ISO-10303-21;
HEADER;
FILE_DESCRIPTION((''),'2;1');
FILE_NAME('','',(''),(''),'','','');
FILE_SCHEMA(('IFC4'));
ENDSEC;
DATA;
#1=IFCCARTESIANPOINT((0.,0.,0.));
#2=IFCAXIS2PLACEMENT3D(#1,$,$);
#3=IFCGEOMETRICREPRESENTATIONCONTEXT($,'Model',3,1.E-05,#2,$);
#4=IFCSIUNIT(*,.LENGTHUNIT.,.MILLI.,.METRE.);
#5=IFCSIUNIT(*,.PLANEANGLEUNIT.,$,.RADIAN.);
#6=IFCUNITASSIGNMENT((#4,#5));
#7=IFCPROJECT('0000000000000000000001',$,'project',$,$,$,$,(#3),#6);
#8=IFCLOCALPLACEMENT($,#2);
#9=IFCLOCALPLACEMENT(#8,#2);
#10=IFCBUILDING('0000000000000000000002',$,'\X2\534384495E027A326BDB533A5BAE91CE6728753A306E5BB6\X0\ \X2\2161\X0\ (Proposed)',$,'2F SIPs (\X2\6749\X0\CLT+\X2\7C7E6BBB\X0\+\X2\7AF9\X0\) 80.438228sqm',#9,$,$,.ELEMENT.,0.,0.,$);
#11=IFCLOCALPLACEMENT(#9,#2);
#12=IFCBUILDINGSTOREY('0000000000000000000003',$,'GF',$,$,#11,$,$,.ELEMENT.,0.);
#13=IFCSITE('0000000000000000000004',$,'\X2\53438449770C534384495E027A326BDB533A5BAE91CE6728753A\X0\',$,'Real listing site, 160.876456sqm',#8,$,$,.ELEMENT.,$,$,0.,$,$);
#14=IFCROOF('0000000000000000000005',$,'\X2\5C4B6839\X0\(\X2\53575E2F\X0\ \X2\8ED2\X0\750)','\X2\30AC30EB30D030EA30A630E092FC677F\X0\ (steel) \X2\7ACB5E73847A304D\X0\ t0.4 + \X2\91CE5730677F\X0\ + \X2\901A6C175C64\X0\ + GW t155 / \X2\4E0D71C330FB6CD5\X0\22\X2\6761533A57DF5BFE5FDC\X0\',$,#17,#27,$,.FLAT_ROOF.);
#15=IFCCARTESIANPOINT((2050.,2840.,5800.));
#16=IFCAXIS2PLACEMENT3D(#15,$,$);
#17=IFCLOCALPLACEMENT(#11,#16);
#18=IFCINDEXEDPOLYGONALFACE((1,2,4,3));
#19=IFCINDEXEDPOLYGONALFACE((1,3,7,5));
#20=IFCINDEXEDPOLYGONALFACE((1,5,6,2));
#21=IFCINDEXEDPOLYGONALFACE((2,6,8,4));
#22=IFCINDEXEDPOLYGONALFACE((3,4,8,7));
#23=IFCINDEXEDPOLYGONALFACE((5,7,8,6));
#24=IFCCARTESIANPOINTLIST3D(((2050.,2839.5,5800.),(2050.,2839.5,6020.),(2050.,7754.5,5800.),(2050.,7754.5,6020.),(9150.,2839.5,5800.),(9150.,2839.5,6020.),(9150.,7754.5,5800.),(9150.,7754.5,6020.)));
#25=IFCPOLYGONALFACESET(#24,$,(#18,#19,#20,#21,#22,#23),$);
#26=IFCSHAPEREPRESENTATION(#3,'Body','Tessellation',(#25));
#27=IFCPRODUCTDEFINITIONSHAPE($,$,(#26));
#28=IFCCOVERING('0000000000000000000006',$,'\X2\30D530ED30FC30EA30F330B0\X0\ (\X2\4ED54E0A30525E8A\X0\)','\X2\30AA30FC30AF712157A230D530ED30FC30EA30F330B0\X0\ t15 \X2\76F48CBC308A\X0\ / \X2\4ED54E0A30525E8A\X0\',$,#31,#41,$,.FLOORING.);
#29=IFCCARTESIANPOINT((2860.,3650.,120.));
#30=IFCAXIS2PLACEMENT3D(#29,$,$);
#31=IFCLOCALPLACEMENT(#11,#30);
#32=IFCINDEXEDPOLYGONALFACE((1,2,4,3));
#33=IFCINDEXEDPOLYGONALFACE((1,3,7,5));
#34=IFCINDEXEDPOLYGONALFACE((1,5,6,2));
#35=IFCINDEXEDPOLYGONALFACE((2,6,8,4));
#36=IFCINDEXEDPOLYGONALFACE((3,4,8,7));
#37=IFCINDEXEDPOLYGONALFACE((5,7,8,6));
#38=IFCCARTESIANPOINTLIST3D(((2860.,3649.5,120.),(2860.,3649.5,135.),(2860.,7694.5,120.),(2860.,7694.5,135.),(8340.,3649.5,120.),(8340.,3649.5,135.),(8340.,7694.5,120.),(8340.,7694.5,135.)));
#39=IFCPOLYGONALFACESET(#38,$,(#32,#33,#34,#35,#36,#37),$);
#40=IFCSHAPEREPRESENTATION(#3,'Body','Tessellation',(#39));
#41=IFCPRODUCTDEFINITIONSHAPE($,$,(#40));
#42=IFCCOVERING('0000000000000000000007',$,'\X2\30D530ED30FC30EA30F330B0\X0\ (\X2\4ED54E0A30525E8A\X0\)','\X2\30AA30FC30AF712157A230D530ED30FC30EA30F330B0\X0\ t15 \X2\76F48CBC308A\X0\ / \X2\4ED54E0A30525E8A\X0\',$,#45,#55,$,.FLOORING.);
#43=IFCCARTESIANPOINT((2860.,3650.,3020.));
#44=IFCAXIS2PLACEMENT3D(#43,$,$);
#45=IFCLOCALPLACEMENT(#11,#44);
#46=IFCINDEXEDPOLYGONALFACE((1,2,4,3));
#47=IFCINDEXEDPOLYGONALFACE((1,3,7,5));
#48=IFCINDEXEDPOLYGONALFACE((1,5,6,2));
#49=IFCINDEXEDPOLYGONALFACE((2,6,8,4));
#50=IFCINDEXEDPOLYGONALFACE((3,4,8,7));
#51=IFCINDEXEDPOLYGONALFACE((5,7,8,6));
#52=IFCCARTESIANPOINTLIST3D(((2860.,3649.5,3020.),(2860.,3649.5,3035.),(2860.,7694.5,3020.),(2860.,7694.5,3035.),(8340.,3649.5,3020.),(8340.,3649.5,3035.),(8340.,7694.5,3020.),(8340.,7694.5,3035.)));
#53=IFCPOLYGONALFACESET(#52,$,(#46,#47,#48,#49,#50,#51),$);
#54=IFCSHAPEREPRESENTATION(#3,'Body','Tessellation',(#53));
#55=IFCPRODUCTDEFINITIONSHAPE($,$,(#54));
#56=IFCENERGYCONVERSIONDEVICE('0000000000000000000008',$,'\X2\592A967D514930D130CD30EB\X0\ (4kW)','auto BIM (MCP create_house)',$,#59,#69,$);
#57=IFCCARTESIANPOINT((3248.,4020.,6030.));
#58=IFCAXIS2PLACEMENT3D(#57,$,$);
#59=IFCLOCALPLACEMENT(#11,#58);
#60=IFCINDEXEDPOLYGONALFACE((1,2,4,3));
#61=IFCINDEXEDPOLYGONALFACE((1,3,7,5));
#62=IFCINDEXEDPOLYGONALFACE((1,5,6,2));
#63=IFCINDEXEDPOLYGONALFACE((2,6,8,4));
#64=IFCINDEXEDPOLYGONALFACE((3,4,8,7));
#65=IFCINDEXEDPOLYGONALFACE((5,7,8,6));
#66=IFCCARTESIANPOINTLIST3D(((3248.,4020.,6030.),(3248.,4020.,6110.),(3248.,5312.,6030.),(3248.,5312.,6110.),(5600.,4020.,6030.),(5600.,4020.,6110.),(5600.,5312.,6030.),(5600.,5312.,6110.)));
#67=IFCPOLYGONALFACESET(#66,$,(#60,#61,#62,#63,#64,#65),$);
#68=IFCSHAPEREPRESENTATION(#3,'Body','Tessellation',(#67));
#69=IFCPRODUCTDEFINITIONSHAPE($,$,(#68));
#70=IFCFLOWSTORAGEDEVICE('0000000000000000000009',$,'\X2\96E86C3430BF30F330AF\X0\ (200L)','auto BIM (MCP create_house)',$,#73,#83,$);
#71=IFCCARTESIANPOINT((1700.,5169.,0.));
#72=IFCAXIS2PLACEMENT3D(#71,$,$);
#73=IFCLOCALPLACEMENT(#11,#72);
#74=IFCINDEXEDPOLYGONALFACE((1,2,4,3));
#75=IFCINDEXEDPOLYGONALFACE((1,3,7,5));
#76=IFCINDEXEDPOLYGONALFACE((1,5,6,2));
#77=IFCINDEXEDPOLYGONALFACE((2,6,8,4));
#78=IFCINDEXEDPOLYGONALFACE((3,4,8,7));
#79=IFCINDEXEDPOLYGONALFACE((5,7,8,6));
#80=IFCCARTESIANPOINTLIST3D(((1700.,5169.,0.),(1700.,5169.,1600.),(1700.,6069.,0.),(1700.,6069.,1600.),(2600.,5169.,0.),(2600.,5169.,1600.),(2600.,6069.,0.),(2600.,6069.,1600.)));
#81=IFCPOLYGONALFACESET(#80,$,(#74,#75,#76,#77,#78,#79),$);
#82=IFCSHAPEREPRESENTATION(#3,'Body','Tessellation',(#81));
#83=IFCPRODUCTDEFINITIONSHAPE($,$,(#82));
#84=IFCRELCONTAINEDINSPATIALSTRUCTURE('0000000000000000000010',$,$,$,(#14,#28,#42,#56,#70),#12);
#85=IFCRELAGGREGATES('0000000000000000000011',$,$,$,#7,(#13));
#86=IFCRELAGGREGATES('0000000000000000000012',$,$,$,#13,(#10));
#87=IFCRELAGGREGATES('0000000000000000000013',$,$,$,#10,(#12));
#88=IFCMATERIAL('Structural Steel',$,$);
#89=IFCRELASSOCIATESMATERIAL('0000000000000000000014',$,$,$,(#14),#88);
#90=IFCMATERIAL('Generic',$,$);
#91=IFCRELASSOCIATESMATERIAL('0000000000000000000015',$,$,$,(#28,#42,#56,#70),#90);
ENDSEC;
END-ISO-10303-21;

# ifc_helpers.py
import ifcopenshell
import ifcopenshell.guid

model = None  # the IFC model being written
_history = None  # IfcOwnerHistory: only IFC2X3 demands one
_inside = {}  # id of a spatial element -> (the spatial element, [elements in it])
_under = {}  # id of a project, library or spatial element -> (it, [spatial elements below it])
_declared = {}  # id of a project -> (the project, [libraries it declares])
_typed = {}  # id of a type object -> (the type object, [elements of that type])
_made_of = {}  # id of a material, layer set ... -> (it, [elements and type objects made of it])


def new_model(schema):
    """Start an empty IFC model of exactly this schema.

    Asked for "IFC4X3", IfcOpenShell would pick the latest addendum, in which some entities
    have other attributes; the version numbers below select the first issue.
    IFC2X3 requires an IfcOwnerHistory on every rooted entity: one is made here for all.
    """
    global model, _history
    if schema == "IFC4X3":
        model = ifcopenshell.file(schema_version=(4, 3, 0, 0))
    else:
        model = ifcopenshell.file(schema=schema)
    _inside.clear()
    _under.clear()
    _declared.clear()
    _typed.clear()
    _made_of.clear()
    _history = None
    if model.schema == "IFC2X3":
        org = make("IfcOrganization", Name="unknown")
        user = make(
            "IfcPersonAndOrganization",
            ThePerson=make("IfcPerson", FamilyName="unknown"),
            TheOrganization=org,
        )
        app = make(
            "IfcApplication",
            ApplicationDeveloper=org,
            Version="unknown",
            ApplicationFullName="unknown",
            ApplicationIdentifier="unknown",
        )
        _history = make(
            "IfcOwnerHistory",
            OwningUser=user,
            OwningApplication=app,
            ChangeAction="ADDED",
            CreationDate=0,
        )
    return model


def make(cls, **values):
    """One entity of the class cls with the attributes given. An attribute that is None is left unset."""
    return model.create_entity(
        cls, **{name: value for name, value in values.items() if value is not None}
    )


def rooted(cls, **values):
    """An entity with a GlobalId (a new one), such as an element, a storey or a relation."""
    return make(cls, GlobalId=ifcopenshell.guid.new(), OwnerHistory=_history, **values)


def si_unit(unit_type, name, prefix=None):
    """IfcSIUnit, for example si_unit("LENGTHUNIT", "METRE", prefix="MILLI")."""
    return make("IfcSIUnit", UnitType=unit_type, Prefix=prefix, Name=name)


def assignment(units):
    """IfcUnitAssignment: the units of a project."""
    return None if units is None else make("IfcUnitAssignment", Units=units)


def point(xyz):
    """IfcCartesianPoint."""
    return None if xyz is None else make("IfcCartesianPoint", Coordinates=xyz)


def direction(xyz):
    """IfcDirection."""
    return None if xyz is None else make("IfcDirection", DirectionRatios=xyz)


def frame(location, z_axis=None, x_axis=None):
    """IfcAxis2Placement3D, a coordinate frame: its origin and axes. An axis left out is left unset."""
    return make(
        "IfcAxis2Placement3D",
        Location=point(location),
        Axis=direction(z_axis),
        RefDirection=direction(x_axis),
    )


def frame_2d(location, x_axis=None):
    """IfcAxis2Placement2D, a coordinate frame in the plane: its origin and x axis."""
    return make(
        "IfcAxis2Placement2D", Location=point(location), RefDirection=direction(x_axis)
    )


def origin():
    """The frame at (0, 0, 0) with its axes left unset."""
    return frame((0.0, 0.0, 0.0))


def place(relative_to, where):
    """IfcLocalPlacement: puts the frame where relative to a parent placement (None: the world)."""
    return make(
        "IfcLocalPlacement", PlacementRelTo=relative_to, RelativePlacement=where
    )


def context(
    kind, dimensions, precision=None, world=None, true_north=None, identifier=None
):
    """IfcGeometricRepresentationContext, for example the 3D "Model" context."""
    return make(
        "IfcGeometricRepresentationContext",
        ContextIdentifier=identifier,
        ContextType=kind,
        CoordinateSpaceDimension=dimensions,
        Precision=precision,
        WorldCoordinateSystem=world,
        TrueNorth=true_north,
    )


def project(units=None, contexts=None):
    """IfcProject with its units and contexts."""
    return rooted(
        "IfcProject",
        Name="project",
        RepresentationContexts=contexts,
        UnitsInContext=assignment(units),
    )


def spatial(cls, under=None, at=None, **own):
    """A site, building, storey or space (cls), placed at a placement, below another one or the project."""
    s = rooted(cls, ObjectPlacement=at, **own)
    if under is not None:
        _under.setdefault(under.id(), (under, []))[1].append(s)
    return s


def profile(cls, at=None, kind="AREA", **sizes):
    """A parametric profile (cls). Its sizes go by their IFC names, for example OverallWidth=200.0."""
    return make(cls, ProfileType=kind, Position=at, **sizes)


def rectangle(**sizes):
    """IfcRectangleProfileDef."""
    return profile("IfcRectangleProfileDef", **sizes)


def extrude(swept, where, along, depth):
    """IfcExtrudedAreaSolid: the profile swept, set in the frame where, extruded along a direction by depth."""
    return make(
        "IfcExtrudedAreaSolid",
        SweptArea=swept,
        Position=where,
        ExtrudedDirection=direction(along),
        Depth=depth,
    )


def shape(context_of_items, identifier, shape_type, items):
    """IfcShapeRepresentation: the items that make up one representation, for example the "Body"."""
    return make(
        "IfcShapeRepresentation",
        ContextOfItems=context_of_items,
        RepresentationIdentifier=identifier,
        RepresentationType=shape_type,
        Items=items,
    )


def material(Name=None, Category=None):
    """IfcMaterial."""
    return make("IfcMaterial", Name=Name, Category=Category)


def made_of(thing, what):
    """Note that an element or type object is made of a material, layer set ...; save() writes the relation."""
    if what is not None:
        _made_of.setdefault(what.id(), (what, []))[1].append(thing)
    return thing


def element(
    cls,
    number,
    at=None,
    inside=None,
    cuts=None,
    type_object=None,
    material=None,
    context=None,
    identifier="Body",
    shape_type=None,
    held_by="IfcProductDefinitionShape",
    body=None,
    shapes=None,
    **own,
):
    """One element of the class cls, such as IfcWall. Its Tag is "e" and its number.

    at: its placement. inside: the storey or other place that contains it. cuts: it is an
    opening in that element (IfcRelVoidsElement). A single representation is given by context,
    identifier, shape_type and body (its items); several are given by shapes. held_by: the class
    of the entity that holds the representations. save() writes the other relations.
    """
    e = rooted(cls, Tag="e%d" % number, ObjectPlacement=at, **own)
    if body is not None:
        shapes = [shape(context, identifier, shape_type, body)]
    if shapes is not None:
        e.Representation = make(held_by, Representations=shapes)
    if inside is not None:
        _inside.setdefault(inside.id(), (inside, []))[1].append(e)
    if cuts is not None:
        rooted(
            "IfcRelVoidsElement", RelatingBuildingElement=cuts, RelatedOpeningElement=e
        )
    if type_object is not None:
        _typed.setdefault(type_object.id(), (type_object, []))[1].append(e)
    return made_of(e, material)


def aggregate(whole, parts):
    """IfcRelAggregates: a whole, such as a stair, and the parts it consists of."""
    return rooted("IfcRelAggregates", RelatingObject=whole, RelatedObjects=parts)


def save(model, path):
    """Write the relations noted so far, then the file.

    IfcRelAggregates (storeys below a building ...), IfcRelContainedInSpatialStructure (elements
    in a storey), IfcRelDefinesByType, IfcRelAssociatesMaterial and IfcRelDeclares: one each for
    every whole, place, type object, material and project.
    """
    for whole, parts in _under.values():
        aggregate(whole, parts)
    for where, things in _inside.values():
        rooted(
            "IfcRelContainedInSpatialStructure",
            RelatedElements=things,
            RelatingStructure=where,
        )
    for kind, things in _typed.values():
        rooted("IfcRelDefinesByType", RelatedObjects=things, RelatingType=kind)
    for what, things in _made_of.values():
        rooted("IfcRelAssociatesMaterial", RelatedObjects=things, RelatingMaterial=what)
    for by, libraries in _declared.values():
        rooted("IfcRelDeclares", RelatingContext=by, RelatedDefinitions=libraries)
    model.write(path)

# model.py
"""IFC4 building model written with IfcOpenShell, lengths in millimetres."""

from ifc_helpers import new_model, si_unit, frame, frame_2d, origin, place, context, project, spatial, rectangle, extrude, material, element, save


model = new_model("IFC4")

# Units and contexts
model_context = context("Model", 3, precision=1e-05, world=origin())
ifc_project = project(units=[si_unit("LENGTHUNIT", "METRE", prefix="MILLI"), si_unit("PLANEANGLEUNIT", "RADIAN")], contexts=[model_context])

# Site, building, storey
site_placement = place(None, origin())
site = spatial("IfcSite", under=ifc_project, at=site_placement, Name="千葉県千葉市稲毛区宮野木町", ObjectType="Real listing site, 160.876456sqm", CompositionType="ELEMENT", RefElevation=0.0)
building_placement = place(site_placement, origin())
building = spatial("IfcBuilding", under=site, at=building_placement, Name="千葉市稲毛区宮野木町の家 Ⅱ (Proposed)", ObjectType="2F SIPs (杉CLT+籾殻+竹) 80.438228sqm", CompositionType="ELEMENT", ElevationOfRefHeight=0.0, ElevationOfTerrain=0.0)
storey_placement = place(building_placement, origin())
storey = spatial("IfcBuildingStorey", under=building, at=storey_placement, Name="GF", CompositionType="ELEMENT", Elevation=0.0)

# Roof
ifc_material_1 = material(Name="Structural Steel")
for number, where, name in (
    (1, (2050.0, 2840.0, 5800.0), "屋根(南帯 軒750)"),
):
    element("IfcRoof", number, at=place(storey_placement, frame(where)), inside=storey, material=ifc_material_1, Name=name, Description="ガルバリウム鋼板 (steel) 立平葺き t0.4 + 野地板 + 通気層 + GW t155 / 不燃・法22条区域対応", PredefinedType="FLAT_ROOF", context=model_context, shape_type="SweptSolid", body=[
        extrude(rectangle(XDim=7100.0, YDim=4915.0, at=frame_2d((3550.0, 2457.0))), frame((2050.0, 2840.0, 5800.0)), (0.0, 0.0, 1.0), 220.0),
    ])

# Coverings
ifc_material_2 = material(Name="Generic")
covering_1_placement = place(storey_placement, frame((2860.0, 3650.0, 120.0)))
element("IfcCovering", 2, at=covering_1_placement, inside=storey, material=ifc_material_2, Name="フローリング (仕上げ床)", Description="オーク無垢フローリング t15 直貼り / 仕上げ床", PredefinedType="FLOORING", context=model_context, shape_type="SweptSolid", body=[
    extrude(rectangle(XDim=5480.0, YDim=4045.0, at=frame_2d((2740.0, 2022.0))), frame((2860.0, 3650.0, 120.0)), (0.0, 0.0, 1.0), 15.0),
])
covering_2_placement = place(storey_placement, frame((2860.0, 3650.0, 3020.0)))
element("IfcCovering", 3, at=covering_2_placement, inside=storey, material=ifc_material_2, Name="フローリング (仕上げ床)", Description="オーク無垢フローリング t15 直貼り / 仕上げ床", PredefinedType="FLOORING", context=model_context, shape_type="SweptSolid", body=[
    extrude(rectangle(XDim=5480.0, YDim=4045.0, at=frame_2d((2740.0, 2022.0))), frame((2860.0, 3650.0, 3020.0)), (0.0, 0.0, 1.0), 15.0),
])

# Energy conversion device
energy_conversion_device_placement = place(storey_placement, frame((3248.0, 4020.0, 6030.0)))
element("IfcEnergyConversionDevice", 4, at=energy_conversion_device_placement, inside=storey, material=ifc_material_2, Name="太陽光パネル (4kW)", Description="auto BIM (MCP create_house)", context=model_context, shape_type="SweptSolid", body=[
    extrude(rectangle(XDim=2352.0, YDim=1292.0, at=frame_2d((1176.0, 646.0))), frame((3248.0, 4020.0, 6030.0)), (0.0, 0.0, 1.0), 80.0),
])

# Flow storage device
flow_storage_device_placement = place(storey_placement, frame((1700.0, 5169.0, 0.0)))
element("IfcFlowStorageDevice", 5, at=flow_storage_device_placement, inside=storey, material=ifc_material_2, Name="雨水タンク (200L)", Description="auto BIM (MCP create_house)", context=model_context, shape_type="SweptSolid", body=[
    extrude(rectangle(XDim=900.0, YDim=900.0, at=frame_2d((450.0, 450.0))), frame((1700.0, 5169.0, 0.0)), (0.0, 0.0, 1.0), 1600.0),
])

save(model, "model.ifc")
